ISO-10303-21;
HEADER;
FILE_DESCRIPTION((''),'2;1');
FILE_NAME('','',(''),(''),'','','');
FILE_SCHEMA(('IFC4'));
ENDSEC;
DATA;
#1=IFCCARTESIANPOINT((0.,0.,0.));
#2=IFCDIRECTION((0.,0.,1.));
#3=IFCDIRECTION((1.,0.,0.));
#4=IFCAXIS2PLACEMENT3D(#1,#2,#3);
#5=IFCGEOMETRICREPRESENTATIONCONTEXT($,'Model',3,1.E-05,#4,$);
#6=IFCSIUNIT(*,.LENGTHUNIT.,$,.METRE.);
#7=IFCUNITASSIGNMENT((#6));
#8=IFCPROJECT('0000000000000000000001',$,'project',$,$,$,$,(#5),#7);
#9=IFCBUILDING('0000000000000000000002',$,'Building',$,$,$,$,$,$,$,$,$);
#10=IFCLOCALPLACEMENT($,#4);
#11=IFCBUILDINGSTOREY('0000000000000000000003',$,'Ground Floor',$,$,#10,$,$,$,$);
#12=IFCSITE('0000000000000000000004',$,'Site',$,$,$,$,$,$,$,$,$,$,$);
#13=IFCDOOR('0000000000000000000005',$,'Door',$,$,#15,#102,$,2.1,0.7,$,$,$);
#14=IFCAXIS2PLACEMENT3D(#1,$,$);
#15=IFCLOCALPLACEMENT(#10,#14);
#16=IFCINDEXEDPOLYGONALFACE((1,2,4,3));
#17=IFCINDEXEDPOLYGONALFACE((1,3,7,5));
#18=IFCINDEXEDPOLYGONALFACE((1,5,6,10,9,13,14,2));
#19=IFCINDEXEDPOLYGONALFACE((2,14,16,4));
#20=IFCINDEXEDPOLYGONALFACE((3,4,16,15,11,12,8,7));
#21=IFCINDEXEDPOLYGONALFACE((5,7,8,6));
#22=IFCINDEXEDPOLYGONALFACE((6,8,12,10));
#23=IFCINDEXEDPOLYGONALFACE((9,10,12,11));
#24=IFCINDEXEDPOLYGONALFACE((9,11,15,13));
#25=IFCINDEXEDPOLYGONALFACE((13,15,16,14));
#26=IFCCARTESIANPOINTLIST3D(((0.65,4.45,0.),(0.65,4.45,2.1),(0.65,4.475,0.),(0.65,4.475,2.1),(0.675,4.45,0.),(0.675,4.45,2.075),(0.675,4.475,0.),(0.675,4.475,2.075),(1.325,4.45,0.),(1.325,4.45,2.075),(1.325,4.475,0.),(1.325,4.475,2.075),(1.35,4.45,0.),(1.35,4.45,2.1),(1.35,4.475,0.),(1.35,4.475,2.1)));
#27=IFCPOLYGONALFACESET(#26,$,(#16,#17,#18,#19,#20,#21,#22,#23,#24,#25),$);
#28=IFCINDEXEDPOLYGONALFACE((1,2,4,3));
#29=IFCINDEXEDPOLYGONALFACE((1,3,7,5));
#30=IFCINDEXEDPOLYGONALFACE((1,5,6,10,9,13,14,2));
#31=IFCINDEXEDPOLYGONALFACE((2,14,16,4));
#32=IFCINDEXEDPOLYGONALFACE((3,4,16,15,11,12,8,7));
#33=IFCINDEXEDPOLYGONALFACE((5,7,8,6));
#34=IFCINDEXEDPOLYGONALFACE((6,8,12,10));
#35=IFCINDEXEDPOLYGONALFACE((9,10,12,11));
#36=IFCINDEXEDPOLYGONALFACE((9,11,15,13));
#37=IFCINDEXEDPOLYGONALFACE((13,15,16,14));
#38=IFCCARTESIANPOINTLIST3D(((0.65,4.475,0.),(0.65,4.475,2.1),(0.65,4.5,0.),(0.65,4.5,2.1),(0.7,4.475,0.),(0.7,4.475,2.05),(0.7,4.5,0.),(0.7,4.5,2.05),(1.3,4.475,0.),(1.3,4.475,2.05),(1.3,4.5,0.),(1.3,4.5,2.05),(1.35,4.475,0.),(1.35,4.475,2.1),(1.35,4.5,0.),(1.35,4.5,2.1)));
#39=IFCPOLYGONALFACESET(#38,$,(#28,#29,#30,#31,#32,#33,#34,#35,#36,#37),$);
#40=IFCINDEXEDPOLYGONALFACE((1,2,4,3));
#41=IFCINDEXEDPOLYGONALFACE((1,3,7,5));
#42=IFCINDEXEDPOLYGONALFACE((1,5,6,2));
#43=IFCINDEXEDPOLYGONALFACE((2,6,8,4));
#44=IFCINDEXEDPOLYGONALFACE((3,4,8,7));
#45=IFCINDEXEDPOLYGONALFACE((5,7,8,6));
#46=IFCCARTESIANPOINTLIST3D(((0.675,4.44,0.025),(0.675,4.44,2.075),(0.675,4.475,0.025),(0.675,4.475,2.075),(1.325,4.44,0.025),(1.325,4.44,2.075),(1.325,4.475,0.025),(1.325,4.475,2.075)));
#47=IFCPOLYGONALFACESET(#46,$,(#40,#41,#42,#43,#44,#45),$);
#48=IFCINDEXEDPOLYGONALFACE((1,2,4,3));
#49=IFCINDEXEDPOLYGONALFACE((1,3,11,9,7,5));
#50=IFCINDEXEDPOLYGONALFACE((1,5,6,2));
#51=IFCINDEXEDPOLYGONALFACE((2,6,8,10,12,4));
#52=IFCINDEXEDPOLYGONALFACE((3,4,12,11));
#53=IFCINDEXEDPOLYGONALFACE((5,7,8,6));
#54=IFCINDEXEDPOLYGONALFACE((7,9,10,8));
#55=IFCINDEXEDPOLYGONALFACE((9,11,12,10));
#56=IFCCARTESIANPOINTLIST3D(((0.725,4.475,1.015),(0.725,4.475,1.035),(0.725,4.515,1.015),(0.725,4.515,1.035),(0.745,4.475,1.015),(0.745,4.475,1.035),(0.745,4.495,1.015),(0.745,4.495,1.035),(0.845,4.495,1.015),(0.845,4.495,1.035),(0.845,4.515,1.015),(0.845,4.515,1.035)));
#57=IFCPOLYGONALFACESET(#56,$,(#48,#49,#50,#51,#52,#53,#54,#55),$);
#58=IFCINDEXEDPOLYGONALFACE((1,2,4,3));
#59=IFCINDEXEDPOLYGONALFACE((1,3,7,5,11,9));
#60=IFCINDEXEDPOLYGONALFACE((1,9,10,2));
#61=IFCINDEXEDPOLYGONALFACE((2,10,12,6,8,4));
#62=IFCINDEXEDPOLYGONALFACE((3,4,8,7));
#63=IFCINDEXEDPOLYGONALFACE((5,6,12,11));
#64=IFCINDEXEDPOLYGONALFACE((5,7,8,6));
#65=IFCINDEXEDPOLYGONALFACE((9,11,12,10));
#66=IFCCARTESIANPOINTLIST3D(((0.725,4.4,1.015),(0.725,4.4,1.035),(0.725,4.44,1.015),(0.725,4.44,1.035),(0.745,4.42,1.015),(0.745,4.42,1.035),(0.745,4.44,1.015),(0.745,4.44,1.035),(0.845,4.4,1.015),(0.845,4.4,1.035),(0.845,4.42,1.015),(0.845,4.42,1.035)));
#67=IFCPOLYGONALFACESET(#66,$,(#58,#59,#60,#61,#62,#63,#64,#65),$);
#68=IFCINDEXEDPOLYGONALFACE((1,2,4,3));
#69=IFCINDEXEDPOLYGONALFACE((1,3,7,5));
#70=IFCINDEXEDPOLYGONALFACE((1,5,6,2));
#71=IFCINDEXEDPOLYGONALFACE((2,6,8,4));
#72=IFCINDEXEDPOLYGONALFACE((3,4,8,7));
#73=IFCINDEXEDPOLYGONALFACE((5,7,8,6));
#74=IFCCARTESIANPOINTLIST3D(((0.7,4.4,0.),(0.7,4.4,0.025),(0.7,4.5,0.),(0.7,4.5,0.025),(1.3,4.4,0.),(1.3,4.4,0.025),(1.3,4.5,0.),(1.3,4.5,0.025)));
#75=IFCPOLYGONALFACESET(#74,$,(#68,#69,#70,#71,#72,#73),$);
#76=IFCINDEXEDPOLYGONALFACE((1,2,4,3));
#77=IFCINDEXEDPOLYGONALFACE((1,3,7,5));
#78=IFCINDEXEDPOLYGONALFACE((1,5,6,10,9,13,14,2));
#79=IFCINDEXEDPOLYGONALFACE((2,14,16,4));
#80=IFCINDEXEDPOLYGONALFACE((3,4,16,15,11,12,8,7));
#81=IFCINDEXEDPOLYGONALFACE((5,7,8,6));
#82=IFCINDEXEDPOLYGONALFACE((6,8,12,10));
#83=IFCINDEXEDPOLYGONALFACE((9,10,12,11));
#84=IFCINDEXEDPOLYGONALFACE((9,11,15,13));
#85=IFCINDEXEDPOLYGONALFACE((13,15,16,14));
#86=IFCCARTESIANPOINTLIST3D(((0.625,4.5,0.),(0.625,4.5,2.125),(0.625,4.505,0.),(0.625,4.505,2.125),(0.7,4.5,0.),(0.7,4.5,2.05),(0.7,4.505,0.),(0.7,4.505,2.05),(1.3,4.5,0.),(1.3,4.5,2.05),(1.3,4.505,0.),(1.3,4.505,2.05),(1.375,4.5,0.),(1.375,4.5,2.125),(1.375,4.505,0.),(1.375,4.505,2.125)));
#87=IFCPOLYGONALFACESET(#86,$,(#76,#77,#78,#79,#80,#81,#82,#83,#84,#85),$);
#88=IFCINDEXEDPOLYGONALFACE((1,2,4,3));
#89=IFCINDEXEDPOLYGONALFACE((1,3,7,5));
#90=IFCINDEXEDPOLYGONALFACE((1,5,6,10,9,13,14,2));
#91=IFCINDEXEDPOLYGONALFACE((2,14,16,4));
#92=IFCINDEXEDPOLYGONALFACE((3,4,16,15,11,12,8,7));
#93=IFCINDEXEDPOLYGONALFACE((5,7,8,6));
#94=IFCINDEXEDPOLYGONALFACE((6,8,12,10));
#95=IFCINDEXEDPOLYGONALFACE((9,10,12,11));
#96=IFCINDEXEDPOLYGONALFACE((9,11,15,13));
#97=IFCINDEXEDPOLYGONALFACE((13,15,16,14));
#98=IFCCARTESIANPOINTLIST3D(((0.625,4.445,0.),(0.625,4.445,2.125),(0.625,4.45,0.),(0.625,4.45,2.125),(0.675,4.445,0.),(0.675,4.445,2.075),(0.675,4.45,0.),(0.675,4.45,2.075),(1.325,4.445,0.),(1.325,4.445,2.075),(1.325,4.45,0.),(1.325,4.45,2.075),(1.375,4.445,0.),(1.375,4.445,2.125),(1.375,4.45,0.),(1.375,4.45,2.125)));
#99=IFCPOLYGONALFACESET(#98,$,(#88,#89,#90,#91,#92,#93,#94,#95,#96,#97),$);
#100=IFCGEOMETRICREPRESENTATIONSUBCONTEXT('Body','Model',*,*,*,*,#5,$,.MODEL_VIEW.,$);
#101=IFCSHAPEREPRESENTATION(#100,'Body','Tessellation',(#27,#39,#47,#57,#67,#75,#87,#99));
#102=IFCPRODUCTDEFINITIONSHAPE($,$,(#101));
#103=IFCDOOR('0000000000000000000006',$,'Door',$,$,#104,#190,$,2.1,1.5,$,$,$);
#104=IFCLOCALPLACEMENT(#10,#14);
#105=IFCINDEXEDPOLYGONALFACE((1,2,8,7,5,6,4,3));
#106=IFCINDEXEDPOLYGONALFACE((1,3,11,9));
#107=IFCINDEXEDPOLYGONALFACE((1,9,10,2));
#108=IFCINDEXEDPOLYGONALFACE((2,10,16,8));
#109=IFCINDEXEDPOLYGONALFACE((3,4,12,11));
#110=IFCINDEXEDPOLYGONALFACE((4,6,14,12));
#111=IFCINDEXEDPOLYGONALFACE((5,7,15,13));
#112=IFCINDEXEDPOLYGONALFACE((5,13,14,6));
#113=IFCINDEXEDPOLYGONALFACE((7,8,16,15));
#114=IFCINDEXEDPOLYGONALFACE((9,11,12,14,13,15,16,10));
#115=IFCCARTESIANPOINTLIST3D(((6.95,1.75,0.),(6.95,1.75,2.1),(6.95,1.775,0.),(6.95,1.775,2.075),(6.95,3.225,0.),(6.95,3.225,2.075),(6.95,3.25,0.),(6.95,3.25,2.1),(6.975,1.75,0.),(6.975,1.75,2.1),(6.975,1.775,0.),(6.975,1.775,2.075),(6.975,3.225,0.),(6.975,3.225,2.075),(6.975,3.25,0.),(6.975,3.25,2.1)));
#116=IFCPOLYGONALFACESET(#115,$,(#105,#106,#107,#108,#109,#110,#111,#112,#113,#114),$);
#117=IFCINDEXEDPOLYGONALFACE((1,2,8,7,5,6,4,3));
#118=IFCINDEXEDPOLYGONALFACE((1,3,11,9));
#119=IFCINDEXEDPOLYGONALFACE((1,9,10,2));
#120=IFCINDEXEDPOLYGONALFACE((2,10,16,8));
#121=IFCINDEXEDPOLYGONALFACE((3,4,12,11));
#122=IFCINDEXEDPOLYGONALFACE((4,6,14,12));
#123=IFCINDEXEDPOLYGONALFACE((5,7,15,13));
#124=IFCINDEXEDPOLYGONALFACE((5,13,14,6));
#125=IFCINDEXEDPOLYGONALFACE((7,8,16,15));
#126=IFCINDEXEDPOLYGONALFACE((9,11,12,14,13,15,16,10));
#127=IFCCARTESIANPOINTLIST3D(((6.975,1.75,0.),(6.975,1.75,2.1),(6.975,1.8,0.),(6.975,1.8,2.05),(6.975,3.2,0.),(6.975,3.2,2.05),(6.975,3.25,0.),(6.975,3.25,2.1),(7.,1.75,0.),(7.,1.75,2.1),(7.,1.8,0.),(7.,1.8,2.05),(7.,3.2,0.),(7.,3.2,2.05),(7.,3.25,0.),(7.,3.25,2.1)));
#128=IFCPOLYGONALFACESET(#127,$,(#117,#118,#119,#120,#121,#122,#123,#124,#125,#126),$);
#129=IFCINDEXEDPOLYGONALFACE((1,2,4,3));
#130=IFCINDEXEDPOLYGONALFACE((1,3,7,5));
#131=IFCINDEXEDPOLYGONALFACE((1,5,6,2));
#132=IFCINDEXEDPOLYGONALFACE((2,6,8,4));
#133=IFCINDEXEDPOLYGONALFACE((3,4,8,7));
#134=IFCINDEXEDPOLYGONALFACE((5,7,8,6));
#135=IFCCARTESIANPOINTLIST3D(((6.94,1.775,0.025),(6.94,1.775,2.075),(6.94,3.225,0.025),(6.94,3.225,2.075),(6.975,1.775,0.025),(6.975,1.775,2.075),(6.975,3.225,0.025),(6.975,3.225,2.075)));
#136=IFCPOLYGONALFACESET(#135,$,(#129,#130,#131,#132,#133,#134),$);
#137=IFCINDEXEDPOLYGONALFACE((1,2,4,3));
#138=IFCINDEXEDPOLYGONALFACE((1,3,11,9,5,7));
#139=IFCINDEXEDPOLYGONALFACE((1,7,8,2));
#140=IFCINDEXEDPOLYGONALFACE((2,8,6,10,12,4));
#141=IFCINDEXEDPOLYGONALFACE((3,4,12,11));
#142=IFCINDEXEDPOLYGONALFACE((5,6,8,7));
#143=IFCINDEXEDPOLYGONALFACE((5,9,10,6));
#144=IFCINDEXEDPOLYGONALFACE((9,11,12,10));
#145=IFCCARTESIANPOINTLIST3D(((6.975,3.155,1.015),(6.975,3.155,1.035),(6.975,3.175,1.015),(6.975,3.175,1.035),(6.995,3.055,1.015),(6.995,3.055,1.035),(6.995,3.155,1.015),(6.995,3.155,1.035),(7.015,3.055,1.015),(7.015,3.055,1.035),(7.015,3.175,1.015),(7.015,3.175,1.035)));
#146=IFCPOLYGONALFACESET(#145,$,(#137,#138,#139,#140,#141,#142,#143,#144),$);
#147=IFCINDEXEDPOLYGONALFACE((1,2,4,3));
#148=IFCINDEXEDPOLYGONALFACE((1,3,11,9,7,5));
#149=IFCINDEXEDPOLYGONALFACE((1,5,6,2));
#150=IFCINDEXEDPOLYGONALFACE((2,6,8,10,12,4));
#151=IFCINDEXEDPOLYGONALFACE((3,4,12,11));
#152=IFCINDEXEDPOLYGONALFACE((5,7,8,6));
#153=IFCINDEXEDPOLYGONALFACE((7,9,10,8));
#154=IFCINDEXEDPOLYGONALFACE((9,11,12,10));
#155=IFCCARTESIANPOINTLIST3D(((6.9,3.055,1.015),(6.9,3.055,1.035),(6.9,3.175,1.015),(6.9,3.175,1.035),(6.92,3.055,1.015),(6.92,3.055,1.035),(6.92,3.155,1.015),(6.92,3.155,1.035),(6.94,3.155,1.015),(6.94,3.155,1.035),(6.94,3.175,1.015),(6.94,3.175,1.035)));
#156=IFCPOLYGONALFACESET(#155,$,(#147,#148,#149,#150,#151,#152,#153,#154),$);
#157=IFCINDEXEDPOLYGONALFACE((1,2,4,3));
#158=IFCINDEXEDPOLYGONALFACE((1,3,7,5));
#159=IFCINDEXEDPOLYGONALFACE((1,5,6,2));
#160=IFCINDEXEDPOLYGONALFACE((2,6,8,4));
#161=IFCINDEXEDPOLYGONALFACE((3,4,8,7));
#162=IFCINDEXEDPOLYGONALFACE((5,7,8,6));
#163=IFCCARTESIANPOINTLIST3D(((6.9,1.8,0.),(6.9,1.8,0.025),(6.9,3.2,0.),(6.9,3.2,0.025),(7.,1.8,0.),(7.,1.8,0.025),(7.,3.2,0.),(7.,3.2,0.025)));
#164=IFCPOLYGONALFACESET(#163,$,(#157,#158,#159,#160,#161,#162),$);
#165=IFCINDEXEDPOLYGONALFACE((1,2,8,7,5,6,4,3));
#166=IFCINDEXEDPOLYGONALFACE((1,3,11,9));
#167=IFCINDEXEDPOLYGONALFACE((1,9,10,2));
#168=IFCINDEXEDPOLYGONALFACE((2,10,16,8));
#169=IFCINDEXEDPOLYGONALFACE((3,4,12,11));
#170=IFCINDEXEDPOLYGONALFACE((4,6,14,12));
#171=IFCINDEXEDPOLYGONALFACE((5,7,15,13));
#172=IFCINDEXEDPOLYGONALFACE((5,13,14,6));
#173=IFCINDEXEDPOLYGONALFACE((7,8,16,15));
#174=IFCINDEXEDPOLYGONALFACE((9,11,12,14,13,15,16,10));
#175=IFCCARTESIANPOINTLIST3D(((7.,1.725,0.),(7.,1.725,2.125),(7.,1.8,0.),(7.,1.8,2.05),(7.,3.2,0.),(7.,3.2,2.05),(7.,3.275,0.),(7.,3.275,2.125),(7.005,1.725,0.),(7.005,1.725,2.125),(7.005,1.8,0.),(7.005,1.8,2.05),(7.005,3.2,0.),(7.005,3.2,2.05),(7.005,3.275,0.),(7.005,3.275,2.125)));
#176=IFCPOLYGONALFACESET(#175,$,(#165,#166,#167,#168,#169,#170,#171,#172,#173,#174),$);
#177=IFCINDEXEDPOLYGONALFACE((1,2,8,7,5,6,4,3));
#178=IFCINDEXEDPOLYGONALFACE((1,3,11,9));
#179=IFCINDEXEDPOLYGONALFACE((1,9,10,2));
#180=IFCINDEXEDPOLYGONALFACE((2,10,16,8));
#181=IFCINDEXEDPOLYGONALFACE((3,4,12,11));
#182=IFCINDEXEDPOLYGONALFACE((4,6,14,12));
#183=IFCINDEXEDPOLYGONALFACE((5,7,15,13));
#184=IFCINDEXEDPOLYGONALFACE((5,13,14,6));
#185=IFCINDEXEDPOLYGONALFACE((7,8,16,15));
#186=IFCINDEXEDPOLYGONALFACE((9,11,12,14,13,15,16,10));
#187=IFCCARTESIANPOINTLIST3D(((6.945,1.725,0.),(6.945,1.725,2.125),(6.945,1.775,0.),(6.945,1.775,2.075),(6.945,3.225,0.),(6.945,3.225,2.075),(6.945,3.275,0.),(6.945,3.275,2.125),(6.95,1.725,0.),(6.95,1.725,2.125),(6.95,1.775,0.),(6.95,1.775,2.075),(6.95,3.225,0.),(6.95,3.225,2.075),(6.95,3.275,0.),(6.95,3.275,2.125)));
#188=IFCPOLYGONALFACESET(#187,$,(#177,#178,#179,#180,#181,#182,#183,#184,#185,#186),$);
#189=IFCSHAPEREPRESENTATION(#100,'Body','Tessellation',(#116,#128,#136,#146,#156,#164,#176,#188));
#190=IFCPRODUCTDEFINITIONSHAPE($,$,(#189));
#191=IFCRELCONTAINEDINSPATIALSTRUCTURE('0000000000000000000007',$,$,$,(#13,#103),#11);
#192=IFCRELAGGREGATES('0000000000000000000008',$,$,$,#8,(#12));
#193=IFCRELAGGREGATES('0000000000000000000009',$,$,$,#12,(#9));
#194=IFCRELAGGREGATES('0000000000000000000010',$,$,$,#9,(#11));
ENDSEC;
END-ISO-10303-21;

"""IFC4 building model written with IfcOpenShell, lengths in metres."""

from ifc_helpers import new_model, si_unit, frame, origin_with_axes, place, context, subcontext, project, spatial, line, indexed_curve, outline, extrude, element, save


model = new_model("IFC4")

# Units and contexts
model_context = context("Model", 3, precision=1e-05, world=origin_with_axes())
body_context = subcontext(model_context, "Body", "Model", "MODEL_VIEW")
ifc_project = project(units=[si_unit("LENGTHUNIT", "METRE")], contexts=[model_context])

# Site, building, storey
site = spatial("IfcSite", under=ifc_project, Name="Site")
building = spatial("IfcBuilding", under=site, Name="Building")
storey_placement = place(None, origin_with_axes())
storey = spatial("IfcBuildingStorey", under=building, at=storey_placement, Name="Ground Floor")

# Doors
door_1_placement = place(storey_placement, frame((1.35, 4.5, 0.0), z_axis=(0.0, 0.0, 1.0), x_axis=(-1.0, 0.0, 0.0)))
element("IfcDoor", 1, at=door_1_placement, inside=storey, Name="Door", OverallHeight=2.1, OverallWidth=0.7, context=body_context, shape_type="SweptSolid", body=[
    extrude(outline(indexed_curve([(0.0, 0.0), (0.0, 2.1), (0.7, 2.1), (0.7, 0.0), (0.675, 0.0), (0.675, 2.075), (0.025, 2.075), (0.025, 0.0)], segments=[line(1, 2, 3, 4, 5, 6, 7, 8, 1)])), frame((0.0, 0.025, 0.0), z_axis=(0.0, -1.0, 0.0), x_axis=(1.0, 0.0, 0.0)), (0.0, 0.0, -1.0), 0.025),
    extrude(outline(indexed_curve([(0.0, 0.0), (0.0, 2.1), (0.7, 2.1), (0.7, 0.0), (0.65, 0.0), (0.65, 2.05), (0.05, 2.05), (0.05, 0.0)], segments=[line(1, 2, 3, 4, 5, 6, 7, 8, 1)])), frame((0.0, 0.0, 0.0), z_axis=(0.0, -1.0, 0.0), x_axis=(1.0, 0.0, 0.0)), (0.0, 0.0, -1.0), 0.025),
    extrude(outline(indexed_curve([(0.0, 0.0), (0.65, 0.0), (0.65, 0.035), (0.0, 0.035)], segments=[line(1, 2, 3, 4, 1)])), frame((0.025, 0.025, 0.025), z_axis=(0.0, 0.0, 1.0), x_axis=(1.0, 0.0, 0.0)), (0.0, 0.0, 1.0), 2.05),
    extrude(outline(indexed_curve([(0.0, 0.0), (0.0, -0.04), (-0.12, -0.04), (-0.12, -0.02), (-0.02, -0.02), (-0.02, 0.0)], segments=[line(1, 2, 3, 4, 5, 6, 1)])), frame((0.625, 0.025, 1.015), z_axis=(0.0, 0.0, 1.0), x_axis=(1.0, 0.0, 0.0)), (0.0, 0.0, 1.0), 0.02),
    extrude(outline(indexed_curve([(0.0, 0.0), (0.0, 0.04), (-0.12, 0.04), (-0.12, 0.02), (-0.02, 0.02), (-0.02, 0.0)], segments=[line(1, 2, 3, 4, 5, 6, 1)])), frame((0.625, 0.06, 1.015), z_axis=(0.0, 0.0, 1.0), x_axis=(1.0, 0.0, 0.0)), (0.0, 0.0, 1.0), 0.02),
    extrude(outline(indexed_curve([(0.0, 0.0), (0.6, 0.0), (0.6, 0.1), (0.0, 0.1)], segments=[line(1, 2, 3, 4, 1)])), frame((0.05, 0.0, 0.0), z_axis=(0.0, 0.0, 1.0), x_axis=(1.0, 0.0, 0.0)), (0.0, 0.0, 1.0), 0.025),
    extrude(outline(indexed_curve([(0.0, 0.0), (0.0, 2.125), (0.75, 2.125), (0.75, 0.0), (0.675, 0.0), (0.675, 2.05), (0.075, 2.05), (0.075, 0.0)], segments=[line(1, 2, 3, 4, 5, 6, 7, 8, 1)])), frame((-0.025, -0.005, 0.0), z_axis=(0.0, -1.0, 0.0), x_axis=(1.0, 0.0, 0.0)), (0.0, 0.0, -1.0), 0.005),
    extrude(outline(indexed_curve([(0.0, 0.0), (0.0, 2.125), (0.75, 2.125), (0.75, 0.0), (0.7, 0.0), (0.7, 2.075), (0.05, 2.075), (0.05, 0.0)], segments=[line(1, 2, 3, 4, 5, 6, 7, 8, 1)])), frame((-0.025, 0.05, 0.0), z_axis=(0.0, -1.0, 0.0), x_axis=(1.0, 0.0, 0.0)), (0.0, 0.0, -1.0), 0.005),
])
door_2_placement = place(storey_placement, frame((7.0, 1.75, 0.0), z_axis=(0.0, 0.0, 1.0), x_axis=(0.0, 1.0, 0.0)))
element("IfcDoor", 2, at=door_2_placement, inside=storey, Name="Door", OverallHeight=2.1, OverallWidth=1.5, context=body_context, shape_type="SweptSolid", body=[
    extrude(outline(indexed_curve([(0.0, 0.0), (0.0, 2.1), (1.5, 2.1), (1.5, 0.0), (1.475, 0.0), (1.475, 2.075), (0.025, 2.075), (0.025, 0.0)], segments=[line(1, 2, 3, 4, 5, 6, 7, 8, 1)])), frame((0.0, 0.025, 0.0), z_axis=(0.0, -1.0, 0.0), x_axis=(1.0, 0.0, 0.0)), (0.0, 0.0, -1.0), 0.025),
    extrude(outline(indexed_curve([(0.0, 0.0), (0.0, 2.1), (1.5, 2.1), (1.5, 0.0), (1.45, 0.0), (1.45, 2.05), (0.05, 2.05), (0.05, 0.0)], segments=[line(1, 2, 3, 4, 5, 6, 7, 8, 1)])), frame((0.0, 0.0, 0.0), z_axis=(0.0, -1.0, 0.0), x_axis=(1.0, 0.0, 0.0)), (0.0, 0.0, -1.0), 0.025),
    extrude(outline(indexed_curve([(0.0, 0.0), (1.45, 0.0), (1.45, 0.035), (0.0, 0.035)], segments=[line(1, 2, 3, 4, 1)])), frame((0.025, 0.025, 0.025), z_axis=(0.0, 0.0, 1.0), x_axis=(1.0, 0.0, 0.0)), (0.0, 0.0, 1.0), 2.05),
    extrude(outline(indexed_curve([(0.0, 0.0), (0.0, -0.04), (-0.12, -0.04), (-0.12, -0.02), (-0.02, -0.02), (-0.02, 0.0)], segments=[line(1, 2, 3, 4, 5, 6, 1)])), frame((1.425, 0.025, 1.015), z_axis=(0.0, 0.0, 1.0), x_axis=(1.0, 0.0, 0.0)), (0.0, 0.0, 1.0), 0.02),
    extrude(outline(indexed_curve([(0.0, 0.0), (0.0, 0.04), (-0.12, 0.04), (-0.12, 0.02), (-0.02, 0.02), (-0.02, 0.0)], segments=[line(1, 2, 3, 4, 5, 6, 1)])), frame((1.425, 0.06, 1.015), z_axis=(0.0, 0.0, 1.0), x_axis=(1.0, 0.0, 0.0)), (0.0, 0.0, 1.0), 0.02),
    extrude(outline(indexed_curve([(0.0, 0.0), (1.4, 0.0), (1.4, 0.1), (0.0, 0.1)], segments=[line(1, 2, 3, 4, 1)])), frame((0.05, 0.0, 0.0), z_axis=(0.0, 0.0, 1.0), x_axis=(1.0, 0.0, 0.0)), (0.0, 0.0, 1.0), 0.025),
    extrude(outline(indexed_curve([(0.0, 0.0), (0.0, 2.125), (1.55, 2.125), (1.55, 0.0), (1.475, 0.0), (1.475, 2.05), (0.075, 2.05), (0.075, 0.0)], segments=[line(1, 2, 3, 4, 5, 6, 7, 8, 1)])), frame((-0.025, -0.005, 0.0), z_axis=(0.0, -1.0, 0.0), x_axis=(1.0, 0.0, 0.0)), (0.0, 0.0, -1.0), 0.005),
    extrude(outline(indexed_curve([(0.0, 0.0), (0.0, 2.125), (1.55, 2.125), (1.55, 0.0), (1.5, 0.0), (1.5, 2.075), (0.05, 2.075), (0.05, 0.0)], segments=[line(1, 2, 3, 4, 5, 6, 7, 8, 1)])), frame((-0.025, 0.05, 0.0), z_axis=(0.0, -1.0, 0.0), x_axis=(1.0, 0.0, 0.0)), (0.0, 0.0, -1.0), 0.005),
])

save(model, "model.ifc")
